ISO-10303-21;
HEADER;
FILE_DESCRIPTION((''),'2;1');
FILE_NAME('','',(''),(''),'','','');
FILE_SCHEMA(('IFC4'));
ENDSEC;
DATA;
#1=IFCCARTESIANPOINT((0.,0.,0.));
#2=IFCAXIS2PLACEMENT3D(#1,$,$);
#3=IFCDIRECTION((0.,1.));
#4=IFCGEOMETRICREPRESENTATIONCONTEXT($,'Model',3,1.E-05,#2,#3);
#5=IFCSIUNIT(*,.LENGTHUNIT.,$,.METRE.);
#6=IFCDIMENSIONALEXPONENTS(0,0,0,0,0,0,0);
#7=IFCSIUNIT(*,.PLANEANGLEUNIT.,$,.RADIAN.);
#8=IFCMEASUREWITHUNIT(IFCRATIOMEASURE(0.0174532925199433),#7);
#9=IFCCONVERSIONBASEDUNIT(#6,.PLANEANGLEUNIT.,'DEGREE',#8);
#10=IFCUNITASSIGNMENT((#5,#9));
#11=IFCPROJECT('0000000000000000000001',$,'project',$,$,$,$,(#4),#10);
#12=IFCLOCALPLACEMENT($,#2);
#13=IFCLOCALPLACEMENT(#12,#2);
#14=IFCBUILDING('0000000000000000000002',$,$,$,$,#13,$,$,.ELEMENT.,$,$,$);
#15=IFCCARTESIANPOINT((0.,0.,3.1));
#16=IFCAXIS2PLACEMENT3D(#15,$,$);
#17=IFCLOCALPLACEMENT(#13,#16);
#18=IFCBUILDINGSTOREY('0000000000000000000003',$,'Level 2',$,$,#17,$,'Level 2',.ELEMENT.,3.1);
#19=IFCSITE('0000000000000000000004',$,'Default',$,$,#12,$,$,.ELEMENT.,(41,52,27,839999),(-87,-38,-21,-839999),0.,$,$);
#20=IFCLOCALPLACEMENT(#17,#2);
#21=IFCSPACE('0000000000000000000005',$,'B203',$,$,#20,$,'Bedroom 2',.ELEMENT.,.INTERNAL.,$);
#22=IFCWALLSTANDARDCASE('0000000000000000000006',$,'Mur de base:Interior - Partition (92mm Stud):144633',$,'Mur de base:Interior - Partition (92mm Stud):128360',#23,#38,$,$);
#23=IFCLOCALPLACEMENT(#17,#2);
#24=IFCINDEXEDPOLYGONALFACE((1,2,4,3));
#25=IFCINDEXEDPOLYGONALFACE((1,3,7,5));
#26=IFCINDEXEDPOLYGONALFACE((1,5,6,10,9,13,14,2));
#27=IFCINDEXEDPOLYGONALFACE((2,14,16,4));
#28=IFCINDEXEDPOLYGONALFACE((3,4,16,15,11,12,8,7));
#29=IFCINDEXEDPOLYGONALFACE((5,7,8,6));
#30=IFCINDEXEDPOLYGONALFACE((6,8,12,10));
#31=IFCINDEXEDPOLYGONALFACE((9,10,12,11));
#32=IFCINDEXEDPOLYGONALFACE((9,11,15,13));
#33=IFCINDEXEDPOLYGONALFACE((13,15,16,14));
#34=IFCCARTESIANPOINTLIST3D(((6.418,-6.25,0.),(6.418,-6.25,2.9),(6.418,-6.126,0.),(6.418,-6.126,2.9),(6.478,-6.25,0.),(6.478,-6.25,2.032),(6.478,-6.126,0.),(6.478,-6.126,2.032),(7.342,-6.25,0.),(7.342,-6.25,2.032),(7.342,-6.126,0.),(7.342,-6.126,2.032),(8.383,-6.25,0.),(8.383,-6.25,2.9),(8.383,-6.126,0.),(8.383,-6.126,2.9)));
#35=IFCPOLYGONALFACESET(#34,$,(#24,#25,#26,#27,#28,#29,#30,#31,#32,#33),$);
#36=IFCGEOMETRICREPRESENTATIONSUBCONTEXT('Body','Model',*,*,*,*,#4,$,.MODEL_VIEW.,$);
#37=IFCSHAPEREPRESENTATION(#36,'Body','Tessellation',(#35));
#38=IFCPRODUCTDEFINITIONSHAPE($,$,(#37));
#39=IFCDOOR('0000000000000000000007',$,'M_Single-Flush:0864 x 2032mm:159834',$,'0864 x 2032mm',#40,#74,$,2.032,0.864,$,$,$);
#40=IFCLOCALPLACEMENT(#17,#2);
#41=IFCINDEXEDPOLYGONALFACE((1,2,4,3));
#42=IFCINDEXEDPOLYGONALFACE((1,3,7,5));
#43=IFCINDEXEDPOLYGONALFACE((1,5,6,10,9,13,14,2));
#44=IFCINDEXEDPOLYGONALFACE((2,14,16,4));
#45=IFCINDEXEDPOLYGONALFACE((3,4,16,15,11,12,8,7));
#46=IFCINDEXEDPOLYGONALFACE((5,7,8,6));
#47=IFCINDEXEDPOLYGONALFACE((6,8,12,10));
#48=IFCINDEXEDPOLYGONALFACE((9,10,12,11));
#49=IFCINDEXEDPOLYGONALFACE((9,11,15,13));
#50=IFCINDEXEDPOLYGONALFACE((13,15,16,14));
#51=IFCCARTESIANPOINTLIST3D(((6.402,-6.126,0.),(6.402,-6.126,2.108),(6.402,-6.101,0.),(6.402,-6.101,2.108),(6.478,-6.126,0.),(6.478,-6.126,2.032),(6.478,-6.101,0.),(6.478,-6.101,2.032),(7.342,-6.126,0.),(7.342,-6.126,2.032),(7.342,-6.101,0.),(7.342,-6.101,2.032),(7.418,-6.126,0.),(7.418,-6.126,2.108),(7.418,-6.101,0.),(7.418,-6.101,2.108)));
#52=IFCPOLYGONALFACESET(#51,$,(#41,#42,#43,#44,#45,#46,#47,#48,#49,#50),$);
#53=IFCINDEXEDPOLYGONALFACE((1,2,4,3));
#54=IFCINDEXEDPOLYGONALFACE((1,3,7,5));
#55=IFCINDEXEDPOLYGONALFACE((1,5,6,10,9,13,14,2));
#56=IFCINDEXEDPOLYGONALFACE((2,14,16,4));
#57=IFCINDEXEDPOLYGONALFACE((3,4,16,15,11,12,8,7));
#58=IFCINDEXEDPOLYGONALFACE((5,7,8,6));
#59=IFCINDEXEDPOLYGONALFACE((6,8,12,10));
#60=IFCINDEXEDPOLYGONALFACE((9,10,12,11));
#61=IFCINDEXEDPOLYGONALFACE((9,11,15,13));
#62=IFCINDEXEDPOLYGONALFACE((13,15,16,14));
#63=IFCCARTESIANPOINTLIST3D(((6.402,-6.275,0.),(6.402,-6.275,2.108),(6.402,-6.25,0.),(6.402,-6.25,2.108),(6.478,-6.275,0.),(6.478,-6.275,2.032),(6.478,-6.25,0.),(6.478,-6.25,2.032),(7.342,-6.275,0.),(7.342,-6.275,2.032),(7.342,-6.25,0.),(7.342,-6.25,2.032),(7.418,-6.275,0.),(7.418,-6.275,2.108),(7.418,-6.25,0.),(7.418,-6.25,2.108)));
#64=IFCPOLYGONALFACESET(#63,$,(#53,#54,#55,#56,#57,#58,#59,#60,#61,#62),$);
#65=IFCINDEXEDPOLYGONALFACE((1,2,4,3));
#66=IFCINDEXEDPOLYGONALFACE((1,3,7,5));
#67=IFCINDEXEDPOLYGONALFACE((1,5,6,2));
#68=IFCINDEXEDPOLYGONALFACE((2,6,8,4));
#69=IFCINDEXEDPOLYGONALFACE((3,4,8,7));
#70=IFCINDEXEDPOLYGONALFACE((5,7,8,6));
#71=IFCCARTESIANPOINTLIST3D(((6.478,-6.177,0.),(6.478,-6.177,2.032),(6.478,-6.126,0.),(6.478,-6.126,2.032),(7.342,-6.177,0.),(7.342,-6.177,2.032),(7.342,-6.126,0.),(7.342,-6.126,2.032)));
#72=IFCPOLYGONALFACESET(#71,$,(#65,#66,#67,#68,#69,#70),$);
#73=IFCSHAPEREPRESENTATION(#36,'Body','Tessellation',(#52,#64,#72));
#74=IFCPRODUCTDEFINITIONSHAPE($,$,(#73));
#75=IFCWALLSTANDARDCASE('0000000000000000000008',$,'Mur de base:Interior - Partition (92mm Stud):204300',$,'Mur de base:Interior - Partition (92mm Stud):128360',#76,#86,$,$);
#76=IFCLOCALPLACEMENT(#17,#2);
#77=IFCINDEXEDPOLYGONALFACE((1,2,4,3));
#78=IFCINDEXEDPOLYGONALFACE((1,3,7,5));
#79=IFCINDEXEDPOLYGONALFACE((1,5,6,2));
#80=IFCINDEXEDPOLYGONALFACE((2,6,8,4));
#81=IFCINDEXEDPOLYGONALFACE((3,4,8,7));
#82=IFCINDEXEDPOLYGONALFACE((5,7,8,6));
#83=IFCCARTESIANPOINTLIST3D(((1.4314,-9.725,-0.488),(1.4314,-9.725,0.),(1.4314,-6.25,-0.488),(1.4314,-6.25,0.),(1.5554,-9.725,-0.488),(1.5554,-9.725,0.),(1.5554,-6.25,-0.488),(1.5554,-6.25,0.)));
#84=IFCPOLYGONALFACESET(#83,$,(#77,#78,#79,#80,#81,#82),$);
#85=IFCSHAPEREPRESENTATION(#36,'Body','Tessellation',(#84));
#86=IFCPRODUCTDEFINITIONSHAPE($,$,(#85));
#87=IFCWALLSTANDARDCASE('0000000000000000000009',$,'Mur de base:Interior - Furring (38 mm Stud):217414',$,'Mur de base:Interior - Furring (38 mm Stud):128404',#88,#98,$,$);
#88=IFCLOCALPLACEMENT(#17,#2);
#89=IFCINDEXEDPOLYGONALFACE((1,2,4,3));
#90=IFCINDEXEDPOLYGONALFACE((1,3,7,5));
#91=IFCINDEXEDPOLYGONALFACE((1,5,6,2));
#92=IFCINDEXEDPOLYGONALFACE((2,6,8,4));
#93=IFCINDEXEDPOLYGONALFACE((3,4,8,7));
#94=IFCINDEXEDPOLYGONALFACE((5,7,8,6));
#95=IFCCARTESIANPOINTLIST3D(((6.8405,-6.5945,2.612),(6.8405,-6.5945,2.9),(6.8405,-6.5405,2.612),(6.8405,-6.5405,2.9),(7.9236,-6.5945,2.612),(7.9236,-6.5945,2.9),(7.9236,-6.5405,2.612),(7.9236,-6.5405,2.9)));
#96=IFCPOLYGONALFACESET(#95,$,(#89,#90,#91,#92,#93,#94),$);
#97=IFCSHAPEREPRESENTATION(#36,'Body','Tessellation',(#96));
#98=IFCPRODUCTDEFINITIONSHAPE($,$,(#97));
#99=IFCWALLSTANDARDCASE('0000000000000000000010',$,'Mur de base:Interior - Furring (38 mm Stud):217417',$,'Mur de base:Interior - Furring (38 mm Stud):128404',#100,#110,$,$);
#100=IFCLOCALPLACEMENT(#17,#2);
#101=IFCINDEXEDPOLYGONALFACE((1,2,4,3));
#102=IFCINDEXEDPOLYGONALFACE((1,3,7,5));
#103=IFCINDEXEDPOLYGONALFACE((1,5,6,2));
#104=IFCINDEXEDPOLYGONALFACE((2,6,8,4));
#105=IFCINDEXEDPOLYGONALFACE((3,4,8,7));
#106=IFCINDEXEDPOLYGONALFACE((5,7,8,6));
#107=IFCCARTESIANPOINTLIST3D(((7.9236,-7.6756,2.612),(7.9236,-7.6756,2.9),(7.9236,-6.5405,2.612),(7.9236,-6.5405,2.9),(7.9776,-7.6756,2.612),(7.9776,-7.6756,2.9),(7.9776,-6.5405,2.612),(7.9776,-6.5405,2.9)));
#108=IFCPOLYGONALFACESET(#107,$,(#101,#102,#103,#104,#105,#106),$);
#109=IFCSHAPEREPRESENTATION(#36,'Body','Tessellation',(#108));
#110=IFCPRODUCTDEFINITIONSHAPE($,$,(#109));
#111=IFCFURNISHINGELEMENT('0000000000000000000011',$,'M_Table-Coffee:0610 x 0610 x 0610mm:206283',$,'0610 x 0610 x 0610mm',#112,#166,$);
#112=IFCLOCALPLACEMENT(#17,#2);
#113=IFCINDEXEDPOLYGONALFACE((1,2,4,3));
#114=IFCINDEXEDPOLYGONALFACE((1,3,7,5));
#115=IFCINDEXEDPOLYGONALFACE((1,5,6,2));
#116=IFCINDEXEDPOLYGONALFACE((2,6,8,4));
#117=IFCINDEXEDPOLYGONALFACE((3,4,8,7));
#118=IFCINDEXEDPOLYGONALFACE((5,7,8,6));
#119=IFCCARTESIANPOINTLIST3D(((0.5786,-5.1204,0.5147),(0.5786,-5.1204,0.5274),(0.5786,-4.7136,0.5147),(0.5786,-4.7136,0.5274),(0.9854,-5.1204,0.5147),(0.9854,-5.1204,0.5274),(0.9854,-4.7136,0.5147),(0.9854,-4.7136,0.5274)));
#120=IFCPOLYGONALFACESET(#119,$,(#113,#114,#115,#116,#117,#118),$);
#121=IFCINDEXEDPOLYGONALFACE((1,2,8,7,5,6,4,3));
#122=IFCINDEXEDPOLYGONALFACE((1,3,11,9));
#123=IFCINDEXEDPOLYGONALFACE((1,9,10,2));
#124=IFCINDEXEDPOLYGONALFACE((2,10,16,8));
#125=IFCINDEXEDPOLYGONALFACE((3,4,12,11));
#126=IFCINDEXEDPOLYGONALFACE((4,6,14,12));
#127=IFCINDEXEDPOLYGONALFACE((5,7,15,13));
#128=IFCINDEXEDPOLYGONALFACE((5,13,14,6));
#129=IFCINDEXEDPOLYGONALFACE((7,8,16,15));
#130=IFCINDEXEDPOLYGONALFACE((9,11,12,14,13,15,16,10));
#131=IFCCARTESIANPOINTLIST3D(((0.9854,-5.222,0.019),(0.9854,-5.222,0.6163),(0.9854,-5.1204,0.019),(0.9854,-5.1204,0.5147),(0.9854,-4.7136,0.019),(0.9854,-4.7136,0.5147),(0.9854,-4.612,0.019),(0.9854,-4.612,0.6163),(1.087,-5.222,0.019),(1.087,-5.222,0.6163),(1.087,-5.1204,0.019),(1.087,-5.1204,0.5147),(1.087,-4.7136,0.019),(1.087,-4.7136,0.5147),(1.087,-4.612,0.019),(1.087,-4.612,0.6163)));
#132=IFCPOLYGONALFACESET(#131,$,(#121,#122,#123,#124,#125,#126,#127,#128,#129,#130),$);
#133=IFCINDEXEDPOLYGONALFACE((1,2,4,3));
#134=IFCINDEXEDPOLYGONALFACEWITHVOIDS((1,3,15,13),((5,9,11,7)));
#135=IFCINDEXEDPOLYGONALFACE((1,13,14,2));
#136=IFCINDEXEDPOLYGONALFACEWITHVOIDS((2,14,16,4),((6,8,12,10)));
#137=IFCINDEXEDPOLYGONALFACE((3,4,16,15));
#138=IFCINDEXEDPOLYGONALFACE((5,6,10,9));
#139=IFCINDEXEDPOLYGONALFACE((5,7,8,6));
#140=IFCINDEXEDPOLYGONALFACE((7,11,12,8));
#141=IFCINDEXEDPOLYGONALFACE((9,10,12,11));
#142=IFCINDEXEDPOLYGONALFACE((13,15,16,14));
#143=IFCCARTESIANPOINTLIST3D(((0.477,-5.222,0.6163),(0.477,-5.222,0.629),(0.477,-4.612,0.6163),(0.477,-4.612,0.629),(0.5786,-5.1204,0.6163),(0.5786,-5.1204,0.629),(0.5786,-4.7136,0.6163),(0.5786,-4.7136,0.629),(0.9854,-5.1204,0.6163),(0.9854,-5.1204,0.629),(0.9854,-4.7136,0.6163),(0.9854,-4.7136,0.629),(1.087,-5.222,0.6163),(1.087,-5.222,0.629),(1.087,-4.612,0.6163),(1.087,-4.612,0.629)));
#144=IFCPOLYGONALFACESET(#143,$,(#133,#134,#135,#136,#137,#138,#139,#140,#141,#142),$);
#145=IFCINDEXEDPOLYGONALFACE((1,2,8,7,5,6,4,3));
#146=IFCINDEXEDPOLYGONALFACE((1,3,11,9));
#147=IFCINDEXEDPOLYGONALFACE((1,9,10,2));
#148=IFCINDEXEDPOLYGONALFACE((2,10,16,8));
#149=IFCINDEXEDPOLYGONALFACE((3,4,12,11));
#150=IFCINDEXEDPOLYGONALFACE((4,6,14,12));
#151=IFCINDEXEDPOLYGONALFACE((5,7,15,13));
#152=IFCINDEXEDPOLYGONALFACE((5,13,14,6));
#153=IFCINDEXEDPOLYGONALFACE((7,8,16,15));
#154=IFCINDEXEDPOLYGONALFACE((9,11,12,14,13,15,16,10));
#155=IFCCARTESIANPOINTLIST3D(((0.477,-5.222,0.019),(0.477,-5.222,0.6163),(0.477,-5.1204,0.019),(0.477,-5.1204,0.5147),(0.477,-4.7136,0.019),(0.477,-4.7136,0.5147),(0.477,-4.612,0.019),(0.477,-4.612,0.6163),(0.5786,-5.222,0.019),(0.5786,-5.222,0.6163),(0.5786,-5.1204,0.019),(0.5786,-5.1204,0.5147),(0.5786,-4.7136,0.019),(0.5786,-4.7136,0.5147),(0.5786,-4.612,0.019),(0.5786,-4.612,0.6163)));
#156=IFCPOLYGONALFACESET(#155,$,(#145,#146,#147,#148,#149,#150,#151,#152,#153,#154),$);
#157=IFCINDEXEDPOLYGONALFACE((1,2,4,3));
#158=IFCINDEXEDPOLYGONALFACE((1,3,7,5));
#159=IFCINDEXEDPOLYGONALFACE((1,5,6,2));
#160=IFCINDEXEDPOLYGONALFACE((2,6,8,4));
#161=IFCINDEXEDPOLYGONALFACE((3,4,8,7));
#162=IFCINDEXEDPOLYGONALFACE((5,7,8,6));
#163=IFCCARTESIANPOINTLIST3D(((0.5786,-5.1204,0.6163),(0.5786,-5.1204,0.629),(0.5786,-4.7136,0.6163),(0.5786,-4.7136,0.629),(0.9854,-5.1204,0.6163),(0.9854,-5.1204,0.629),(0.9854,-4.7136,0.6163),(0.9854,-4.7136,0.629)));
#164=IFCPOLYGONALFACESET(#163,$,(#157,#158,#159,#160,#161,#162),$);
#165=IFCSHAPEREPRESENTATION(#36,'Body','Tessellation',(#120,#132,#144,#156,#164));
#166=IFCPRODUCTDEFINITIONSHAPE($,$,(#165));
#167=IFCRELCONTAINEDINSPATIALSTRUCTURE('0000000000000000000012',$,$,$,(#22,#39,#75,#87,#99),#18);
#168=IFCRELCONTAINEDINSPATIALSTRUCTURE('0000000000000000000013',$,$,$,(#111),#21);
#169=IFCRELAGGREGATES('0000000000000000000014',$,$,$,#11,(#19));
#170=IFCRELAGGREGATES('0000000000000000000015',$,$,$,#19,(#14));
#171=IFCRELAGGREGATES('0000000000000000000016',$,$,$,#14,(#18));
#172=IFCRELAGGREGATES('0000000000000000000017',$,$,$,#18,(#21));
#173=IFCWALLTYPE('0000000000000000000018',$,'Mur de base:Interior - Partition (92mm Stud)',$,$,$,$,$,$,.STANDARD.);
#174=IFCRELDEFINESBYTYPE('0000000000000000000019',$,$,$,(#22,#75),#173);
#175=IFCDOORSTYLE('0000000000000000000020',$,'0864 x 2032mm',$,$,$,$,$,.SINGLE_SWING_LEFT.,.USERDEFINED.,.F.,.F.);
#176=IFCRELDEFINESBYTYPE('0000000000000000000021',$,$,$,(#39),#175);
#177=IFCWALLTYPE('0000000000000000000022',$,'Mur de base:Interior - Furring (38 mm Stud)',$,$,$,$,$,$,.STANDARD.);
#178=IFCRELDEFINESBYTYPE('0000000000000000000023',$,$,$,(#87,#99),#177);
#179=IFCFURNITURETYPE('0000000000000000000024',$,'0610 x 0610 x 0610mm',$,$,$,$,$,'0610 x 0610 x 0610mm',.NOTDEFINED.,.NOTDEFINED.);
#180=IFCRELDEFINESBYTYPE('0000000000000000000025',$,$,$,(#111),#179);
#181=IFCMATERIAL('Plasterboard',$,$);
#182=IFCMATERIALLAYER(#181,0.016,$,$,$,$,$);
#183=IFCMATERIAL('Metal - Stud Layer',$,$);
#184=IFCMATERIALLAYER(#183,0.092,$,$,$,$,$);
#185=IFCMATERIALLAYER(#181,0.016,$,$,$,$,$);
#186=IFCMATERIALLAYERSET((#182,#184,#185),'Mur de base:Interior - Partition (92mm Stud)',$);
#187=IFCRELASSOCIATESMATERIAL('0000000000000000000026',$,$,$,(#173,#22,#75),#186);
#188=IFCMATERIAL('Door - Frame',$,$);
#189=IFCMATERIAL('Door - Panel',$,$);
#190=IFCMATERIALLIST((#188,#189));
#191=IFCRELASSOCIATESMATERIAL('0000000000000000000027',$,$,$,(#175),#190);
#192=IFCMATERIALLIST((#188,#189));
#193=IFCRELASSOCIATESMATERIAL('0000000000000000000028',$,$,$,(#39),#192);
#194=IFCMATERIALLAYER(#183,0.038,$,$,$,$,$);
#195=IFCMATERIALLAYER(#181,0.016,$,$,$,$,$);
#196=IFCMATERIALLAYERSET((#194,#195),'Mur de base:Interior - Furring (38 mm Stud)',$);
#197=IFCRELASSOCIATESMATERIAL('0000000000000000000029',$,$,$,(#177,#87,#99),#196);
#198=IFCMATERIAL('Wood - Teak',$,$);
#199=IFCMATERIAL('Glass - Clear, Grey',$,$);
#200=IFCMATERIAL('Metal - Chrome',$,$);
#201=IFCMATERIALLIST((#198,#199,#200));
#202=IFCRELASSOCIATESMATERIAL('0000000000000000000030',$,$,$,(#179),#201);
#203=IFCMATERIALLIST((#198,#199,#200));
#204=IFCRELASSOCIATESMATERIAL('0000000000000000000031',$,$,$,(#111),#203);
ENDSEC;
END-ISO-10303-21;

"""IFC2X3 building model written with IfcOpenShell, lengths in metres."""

from ifc_helpers import new_model, entity, si_unit, converted_unit, direction, frame, frame_2d, origin, origin_2d_with_axis, place, context, subcontext, project, spatial, polyline, rectangle, outline, extrude, source, transform, mapped, material, material_list, layer, layer_set, layer_usage, type_object, type_shapes, element, fill, save


model = new_model("IFC2X3")

# Units and contexts
model_context = context("Model", 3, precision=1e-05, world=origin(), true_north=direction((0.0, 1.0)))
body_context = subcontext(model_context, "Body", "Model", "MODEL_VIEW")
ifc_project = project(units=[si_unit("LENGTHUNIT", "METRE"), converted_unit("PLANEANGLEUNIT", "DEGREE", entity("IfcRatioMeasure", 0.0174532925199433), si_unit("PLANEANGLEUNIT", "RADIAN"), dimensions=[0, 0, 0, 0, 0, 0, 0])], contexts=[model_context])

# Site, building, storey
site_placement = place(None, origin())
site = spatial("IfcSite", under=ifc_project, at=site_placement, Name="Default", CompositionType="ELEMENT", RefLatitude=(41, 52, 27, 839999), RefLongitude=(-87, -38, -21, -839999), RefElevation=0.0)
building_placement = place(site_placement, origin())
building = spatial("IfcBuilding", under=site, at=building_placement, CompositionType="ELEMENT")
storey_placement = place(building_placement, frame((0.0, 0.0, 3.1)))
storey = spatial("IfcBuildingStorey", under=building, at=storey_placement, Name="Level 2", LongName="Level 2", CompositionType="ELEMENT", Elevation=3.1)

# Shared definitions
ifc_material_1 = material(Name="Metal - Stud Layer")
ifc_material_2 = material(Name="Plasterboard")

# Wall, opening, door
ifc_layer_1 = layer(ifc_material_2, 0.016)
ifc_layer_2 = layer(ifc_material_1, 0.092)
ifc_layer_3 = layer(ifc_material_2, 0.016)
ifc_layer_set_1 = layer_set([ifc_layer_1, ifc_layer_2, ifc_layer_3], Name="Mur de base:Interior - Partition (92mm Stud)")
wall_type_1 = type_object("IfcWallType", Name="Mur de base:Interior - Partition (92mm Stud)", PredefinedType="STANDARD", material=ifc_layer_set_1)
ifc_material_3 = material(Name="Door - Frame")
ifc_material_4 = material(Name="Door - Panel")
ifc_layer_usage_1 = layer_usage(ifc_layer_set_1, "AXIS2", "NEGATIVE", 0.062)
wall_1_placement = place(storey_placement, frame((6.418, -6.188, 0.0)))
wall_1 = element("IfcWallStandardCase", 1, at=wall_1_placement, inside=storey, type_object=wall_type_1, material=ifc_layer_usage_1, Name="Mur de base:Interior - Partition (92mm Stud):144633", ObjectType="Mur de base:Interior - Partition (92mm Stud):128360", context=body_context, shape_type="SweptSolid", body=[
    extrude(rectangle(XDim=1.965, YDim=0.124, at=frame_2d((0.9825, 0.0), x_axis=(-1.0, 0.0))), origin(), (0.0, 0.0, 1.0), 2.9),
])
opening_1_placement = place(wall_1_placement, frame((0.06, -0.062, 0.0)))
opening_1 = element("IfcOpeningElement", 2, at=opening_1_placement, cuts=wall_1, ObjectType="Opening", context=body_context, shape_type="SweptSolid", body=[
    extrude(rectangle(XDim=0.864, YDim=2.032, at=frame_2d((1.016, 0.432), x_axis=(0.0, -1.0))), frame((0.0, 0.0, 0.0), z_axis=(0.0, 1.0, 0.0), x_axis=(0.0, 0.0, 1.0)), (0.0, 0.0, 1.0), 0.124),
])
ifc_material_list_1 = material_list([ifc_material_3, ifc_material_4])
ifc_material_list_2 = material_list([ifc_material_3, ifc_material_4])
door_style_1 = type_object("IfcDoorStyle", Name="0864 x 2032mm", ConstructionType="USERDEFINED", OperationType="SINGLE_SWING_LEFT", ParameterTakesPrecedence=False, Sizeable=False, material=ifc_material_list_2)
shared_shape_1 = source(origin(), body_context, "Body", "SweptSolid", [
    extrude(outline(polyline([(-0.508, -1.073), (0.508, -1.073), (0.508, 1.035), (0.432, 1.035), (0.432, -0.997), (-0.432, -0.997), (-0.432, 1.035), (-0.508, 1.035), (-0.508, -1.073)])), frame((0.432, 0.149, 1.035), z_axis=(0.0, -1.0, 0.0), x_axis=(-1.0, 0.0, 0.0)), (0.0, 0.0, 1.0), 0.025),
    extrude(outline(polyline([(-1.073, -0.508), (1.035, -0.508), (1.035, -0.432), (-0.997, -0.432), (-0.997, 0.432), (1.035, 0.432), (1.035, 0.508), (-1.073, 0.508), (-1.073, -0.508)])), frame((0.432, 0.0, 1.035), z_axis=(0.0, -1.0, 0.0), x_axis=(0.0, 0.0, -1.0)), (0.0, 0.0, 1.0), 0.025),
    extrude(rectangle(XDim=0.864, YDim=0.051, at=frame_2d((0.0, 0.0), x_axis=(1.0, 0.0))), frame((0.432, 0.0985, 0.0)), (0.0, 0.0, 1.0), 2.032),
])
type_shapes(door_style_1, [shared_shape_1])
door_1_placement = place(opening_1_placement, origin())
door_1 = element("IfcDoor", 3, at=door_1_placement, inside=storey, type_object=door_style_1, material=ifc_material_list_1, Name="M_Single-Flush:0864 x 2032mm:159834", ObjectType="0864 x 2032mm", OverallHeight=2.032, OverallWidth=0.864, context=body_context, shape_type="MappedRepresentation", body=[
    mapped(shared_shape_1, transform((0.0, 0.0, 0.0), scale=1.0)),
])
fill(opening_1, door_1)

# Walls
ifc_layer_usage_2 = layer_usage(ifc_layer_set_1, "AXIS2", "NEGATIVE", 0.062)
wall_2_placement = place(storey_placement, frame((1.4934, -6.25, -0.488), z_axis=(0.0, 0.0, 1.0), x_axis=(0.0, -1.0, 0.0)))
element("IfcWallStandardCase", 4, at=wall_2_placement, inside=storey, type_object=wall_type_1, material=ifc_layer_usage_2, Name="Mur de base:Interior - Partition (92mm Stud):204300", ObjectType="Mur de base:Interior - Partition (92mm Stud):128360", context=body_context, shape_type="SweptSolid", body=[
    extrude(rectangle(XDim=3.475, YDim=0.124, at=frame_2d((1.7375, 0.0), x_axis=(-1.0, 0.0))), origin(), (0.0, 0.0, 1.0), 0.488),
])
ifc_layer_4 = layer(ifc_material_1, 0.038)
ifc_layer_5 = layer(ifc_material_2, 0.016)
ifc_layer_set_2 = layer_set([ifc_layer_4, ifc_layer_5], Name="Mur de base:Interior - Furring (38 mm Stud)")
ifc_layer_usage_3 = layer_usage(ifc_layer_set_2, "AXIS2", "NEGATIVE", 0.027)
wall_type_2 = type_object("IfcWallType", Name="Mur de base:Interior - Furring (38 mm Stud)", PredefinedType="STANDARD", material=ifc_layer_set_2)
wall_3_placement = place(storey_placement, frame((6.8405, -6.5675, 2.612)))
element("IfcWallStandardCase", 5, at=wall_3_placement, inside=storey, type_object=wall_type_2, material=ifc_layer_usage_3, Name="Mur de base:Interior - Furring (38 mm Stud):217414", ObjectType="Mur de base:Interior - Furring (38 mm Stud):128404", context=body_context, shape_type="SweptSolid", body=[
    extrude(rectangle(XDim=1.0831, YDim=0.054, at=frame_2d((0.5415, 0.0), x_axis=(-1.0, 0.0))), origin(), (0.0, 0.0, 1.0), 0.288),
])
ifc_layer_usage_4 = layer_usage(ifc_layer_set_2, "AXIS2", "NEGATIVE", 0.027)
wall_4_placement = place(storey_placement, frame((7.9506, -6.5405, 2.612), z_axis=(0.0, 0.0, 1.0), x_axis=(0.0, -1.0, 0.0)))
element("IfcWallStandardCase", 6, at=wall_4_placement, inside=storey, type_object=wall_type_2, material=ifc_layer_usage_4, Name="Mur de base:Interior - Furring (38 mm Stud):217417", ObjectType="Mur de base:Interior - Furring (38 mm Stud):128404", context=body_context, shape_type="SweptSolid", body=[
    extrude(rectangle(XDim=1.1351, YDim=0.054, at=frame_2d((0.5675, 0.0), x_axis=(-1.0, 0.0))), origin(), (0.0, 0.0, 1.0), 0.288),
])

# Shared definitions
space_1_placement = place(storey_placement, origin())
space_1 = spatial("IfcSpace", under=storey, at=space_1_placement, Name="B203", LongName="Bedroom 2", CompositionType="ELEMENT", InteriorOrExteriorSpace="INTERNAL")

# Furnishing element
ifc_material_5 = material(Name="Wood - Teak")
ifc_material_6 = material(Name="Glass - Clear, Grey")
ifc_material_7 = material(Name="Metal - Chrome")
ifc_material_list_3 = material_list([ifc_material_5, ifc_material_6, ifc_material_7])
ifc_material_list_4 = material_list([ifc_material_5, ifc_material_6, ifc_material_7])
furniture_type_1 = type_object("IfcFurnitureType", Name="0610 x 0610 x 0610mm", ElementType="0610 x 0610 x 0610mm", AssemblyPlace="NOTDEFINED", material=ifc_material_list_4)
shared_shape_2 = source(origin(), body_context, "Body", "SweptSolid", [
    extrude(rectangle(XDim=0.4068, YDim=0.4068, at=origin_2d_with_axis()), frame((0.0183, 0.0952, 0.4957), z_axis=(0.0, 0.0, 1.0), x_axis=(-1.0, 0.0, 0.0)), (0.0, 0.0, 1.0), 0.0127),
    extrude(outline(polyline([(-0.2732, -0.305), (0.324, -0.305), (0.324, 0.305), (-0.2732, 0.305), (-0.2732, 0.2034), (0.2225, 0.2034), (0.2225, -0.2034), (-0.2732, -0.2034), (-0.2732, -0.305)])), frame((0.2217, 0.0952, 0.2732), z_axis=(1.0, 0.0, 0.0), x_axis=(0.0, 0.0, 1.0)), (0.0, 0.0, 1.0), 0.1016),
    extrude(outline(polyline([(-0.305, -0.305), (0.305, -0.305), (0.305, 0.305), (-0.305, 0.305), (-0.305, -0.305)]), holes=[polyline([(-0.2034, -0.2034), (-0.2034, 0.2034), (0.2034, 0.2034), (0.2034, -0.2034), (-0.2034, -0.2034)])]), frame((0.0183, 0.0952, 0.5973), z_axis=(0.0, 0.0, 1.0), x_axis=(-1.0, 0.0, 0.0)), (0.0, 0.0, 1.0), 0.0127),
    extrude(outline(polyline([(-0.305, -0.3241), (0.305, -0.3241), (0.305, 0.2733), (0.2034, 0.2733), (0.2034, -0.2224), (-0.2034, -0.2224), (-0.2034, 0.2733), (-0.305, 0.2733), (-0.305, -0.3241)])), frame((-0.2867, 0.0952, 0.2733), z_axis=(1.0, 0.0, 0.0), x_axis=(0.0, -1.0, 0.0)), (0.0, 0.0, 1.0), 0.1016),
    extrude(rectangle(XDim=0.4068, YDim=0.4068, at=origin_2d_with_axis()), frame((0.0183, 0.0952, 0.5973), z_axis=(0.0, 0.0, 1.0), x_axis=(-1.0, 0.0, 0.0)), (0.0, 0.0, 1.0), 0.0127),
])
type_shapes(furniture_type_1, [shared_shape_2])
furnishing_1_placement = place(space_1_placement, frame((0.7637, -5.0122, 0.019)))
element("IfcFurnishingElement", 7, at=furnishing_1_placement, inside=space_1, type_object=furniture_type_1, material=ifc_material_list_3, Name="M_Table-Coffee:0610 x 0610 x 0610mm:206283", ObjectType="0610 x 0610 x 0610mm", context=body_context, shape_type="MappedRepresentation", body=[
    mapped(shared_shape_2, transform((0.0, 0.0, 0.0), scale=1.0)),
])

save(model, "model.ifc")
